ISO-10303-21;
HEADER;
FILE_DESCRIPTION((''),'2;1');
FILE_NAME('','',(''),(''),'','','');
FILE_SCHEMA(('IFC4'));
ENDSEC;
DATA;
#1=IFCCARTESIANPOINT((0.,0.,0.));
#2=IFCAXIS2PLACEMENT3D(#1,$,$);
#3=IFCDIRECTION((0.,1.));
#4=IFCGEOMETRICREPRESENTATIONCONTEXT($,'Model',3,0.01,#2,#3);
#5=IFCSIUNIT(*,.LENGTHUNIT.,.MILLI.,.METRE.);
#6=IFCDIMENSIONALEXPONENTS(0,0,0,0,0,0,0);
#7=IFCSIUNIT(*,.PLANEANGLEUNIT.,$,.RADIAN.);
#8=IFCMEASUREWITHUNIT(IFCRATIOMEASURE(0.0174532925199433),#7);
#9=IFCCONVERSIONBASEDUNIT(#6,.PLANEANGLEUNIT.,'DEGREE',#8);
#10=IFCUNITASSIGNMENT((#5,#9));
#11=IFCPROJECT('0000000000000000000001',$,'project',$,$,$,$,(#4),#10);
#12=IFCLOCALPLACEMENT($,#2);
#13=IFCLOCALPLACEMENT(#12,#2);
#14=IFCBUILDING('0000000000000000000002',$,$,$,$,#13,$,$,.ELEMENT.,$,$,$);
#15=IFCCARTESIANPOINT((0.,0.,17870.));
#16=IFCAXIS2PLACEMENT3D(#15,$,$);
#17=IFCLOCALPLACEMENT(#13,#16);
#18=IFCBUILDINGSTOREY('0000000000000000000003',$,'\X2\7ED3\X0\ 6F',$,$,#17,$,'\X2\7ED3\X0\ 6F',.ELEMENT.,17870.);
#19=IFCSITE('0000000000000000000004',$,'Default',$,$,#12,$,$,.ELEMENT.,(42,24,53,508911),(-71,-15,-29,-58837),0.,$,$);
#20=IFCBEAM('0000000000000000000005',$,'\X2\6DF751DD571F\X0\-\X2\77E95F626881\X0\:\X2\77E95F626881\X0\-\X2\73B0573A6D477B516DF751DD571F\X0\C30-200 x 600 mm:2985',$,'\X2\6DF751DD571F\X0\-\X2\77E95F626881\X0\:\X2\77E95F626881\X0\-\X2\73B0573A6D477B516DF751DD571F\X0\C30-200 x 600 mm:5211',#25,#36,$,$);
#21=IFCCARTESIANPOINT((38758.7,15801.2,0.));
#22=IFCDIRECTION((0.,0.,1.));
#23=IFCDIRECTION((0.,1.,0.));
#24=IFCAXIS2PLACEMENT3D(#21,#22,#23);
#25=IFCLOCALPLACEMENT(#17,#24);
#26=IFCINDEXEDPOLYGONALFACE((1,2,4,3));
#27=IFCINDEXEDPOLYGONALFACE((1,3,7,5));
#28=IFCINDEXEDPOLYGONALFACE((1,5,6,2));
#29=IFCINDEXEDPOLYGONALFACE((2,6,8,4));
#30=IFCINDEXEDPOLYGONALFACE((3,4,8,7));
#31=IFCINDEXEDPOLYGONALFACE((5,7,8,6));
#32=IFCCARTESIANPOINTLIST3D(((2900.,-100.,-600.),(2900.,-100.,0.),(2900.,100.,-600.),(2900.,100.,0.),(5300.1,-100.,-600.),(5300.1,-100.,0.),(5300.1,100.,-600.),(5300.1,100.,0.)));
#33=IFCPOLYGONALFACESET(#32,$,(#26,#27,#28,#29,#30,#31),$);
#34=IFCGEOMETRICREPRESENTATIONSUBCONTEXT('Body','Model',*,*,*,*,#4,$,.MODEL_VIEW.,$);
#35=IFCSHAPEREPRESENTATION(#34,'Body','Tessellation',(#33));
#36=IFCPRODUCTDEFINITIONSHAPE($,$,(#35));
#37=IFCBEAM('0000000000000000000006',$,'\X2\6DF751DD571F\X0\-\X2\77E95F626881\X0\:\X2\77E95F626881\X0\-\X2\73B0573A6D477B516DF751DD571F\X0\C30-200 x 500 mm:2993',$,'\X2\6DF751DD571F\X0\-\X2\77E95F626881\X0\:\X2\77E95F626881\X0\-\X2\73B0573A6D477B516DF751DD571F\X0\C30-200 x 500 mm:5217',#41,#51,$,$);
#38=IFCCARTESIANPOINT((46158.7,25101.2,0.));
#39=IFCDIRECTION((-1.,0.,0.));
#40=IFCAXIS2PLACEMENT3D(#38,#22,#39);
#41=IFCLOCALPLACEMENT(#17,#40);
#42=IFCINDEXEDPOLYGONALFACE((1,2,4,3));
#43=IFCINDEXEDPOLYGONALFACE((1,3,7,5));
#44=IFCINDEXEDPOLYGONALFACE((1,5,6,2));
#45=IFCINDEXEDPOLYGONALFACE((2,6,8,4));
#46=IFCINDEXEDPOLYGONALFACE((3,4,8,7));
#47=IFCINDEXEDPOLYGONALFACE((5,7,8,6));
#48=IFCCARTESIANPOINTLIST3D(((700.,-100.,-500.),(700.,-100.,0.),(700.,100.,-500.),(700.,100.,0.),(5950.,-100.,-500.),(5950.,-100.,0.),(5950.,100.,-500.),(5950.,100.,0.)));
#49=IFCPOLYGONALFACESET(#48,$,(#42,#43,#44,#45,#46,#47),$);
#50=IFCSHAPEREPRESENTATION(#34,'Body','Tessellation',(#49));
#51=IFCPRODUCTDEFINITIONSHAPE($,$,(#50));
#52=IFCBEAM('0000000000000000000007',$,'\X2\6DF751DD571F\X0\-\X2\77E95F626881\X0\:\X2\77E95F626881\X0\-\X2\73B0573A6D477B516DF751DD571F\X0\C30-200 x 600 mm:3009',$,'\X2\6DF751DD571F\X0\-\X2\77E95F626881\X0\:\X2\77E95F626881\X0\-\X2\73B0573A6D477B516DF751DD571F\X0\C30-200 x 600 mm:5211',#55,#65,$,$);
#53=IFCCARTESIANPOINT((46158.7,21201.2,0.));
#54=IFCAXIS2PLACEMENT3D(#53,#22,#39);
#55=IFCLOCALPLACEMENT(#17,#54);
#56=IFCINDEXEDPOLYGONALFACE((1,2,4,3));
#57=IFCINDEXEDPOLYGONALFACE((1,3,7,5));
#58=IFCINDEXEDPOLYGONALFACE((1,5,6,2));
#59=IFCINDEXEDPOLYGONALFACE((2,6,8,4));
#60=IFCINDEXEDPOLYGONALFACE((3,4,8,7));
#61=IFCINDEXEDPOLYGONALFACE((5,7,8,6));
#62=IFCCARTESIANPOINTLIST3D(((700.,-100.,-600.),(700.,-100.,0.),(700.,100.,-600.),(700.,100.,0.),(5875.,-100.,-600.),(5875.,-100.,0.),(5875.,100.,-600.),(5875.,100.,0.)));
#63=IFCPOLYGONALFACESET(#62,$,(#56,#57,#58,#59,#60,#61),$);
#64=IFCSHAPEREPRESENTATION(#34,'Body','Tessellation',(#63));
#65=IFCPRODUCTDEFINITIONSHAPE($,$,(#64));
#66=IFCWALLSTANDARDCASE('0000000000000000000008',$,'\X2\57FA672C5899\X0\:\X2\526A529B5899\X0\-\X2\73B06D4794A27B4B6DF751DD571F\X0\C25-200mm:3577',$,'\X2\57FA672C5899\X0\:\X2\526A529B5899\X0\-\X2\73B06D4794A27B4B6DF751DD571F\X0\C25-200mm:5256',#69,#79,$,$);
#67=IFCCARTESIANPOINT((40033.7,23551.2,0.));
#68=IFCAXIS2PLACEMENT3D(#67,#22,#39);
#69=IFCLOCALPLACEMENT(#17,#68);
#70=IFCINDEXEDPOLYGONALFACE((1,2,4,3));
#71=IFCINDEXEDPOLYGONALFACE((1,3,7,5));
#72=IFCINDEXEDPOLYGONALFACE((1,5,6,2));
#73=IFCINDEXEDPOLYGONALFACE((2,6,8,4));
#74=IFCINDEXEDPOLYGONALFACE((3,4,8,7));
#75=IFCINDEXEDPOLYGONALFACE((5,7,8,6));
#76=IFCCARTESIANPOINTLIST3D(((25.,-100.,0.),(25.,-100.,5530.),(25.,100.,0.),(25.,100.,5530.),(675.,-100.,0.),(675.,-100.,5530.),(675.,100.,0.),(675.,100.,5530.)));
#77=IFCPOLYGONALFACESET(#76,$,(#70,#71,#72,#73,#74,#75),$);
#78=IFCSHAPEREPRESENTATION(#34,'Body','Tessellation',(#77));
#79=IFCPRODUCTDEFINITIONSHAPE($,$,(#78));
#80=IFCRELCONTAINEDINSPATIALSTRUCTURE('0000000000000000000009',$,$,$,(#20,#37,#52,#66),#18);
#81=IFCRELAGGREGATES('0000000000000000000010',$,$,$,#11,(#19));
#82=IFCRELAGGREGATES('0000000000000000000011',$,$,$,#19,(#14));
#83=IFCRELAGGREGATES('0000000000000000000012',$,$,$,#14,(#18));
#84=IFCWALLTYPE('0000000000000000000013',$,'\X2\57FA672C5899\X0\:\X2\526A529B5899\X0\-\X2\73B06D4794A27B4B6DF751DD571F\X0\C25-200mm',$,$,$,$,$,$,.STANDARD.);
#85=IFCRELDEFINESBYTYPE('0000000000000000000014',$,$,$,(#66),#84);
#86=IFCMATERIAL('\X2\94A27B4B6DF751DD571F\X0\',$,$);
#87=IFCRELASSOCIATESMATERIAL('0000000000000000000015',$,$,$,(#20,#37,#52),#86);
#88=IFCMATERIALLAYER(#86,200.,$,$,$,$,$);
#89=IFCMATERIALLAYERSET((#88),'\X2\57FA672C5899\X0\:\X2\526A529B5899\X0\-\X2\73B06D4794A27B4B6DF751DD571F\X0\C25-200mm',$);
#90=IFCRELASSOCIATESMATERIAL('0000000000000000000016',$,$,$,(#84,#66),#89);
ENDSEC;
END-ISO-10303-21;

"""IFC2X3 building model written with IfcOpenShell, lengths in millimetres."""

from ifc_helpers import new_model, entity, si_unit, converted_unit, direction, frame, frame_2d, origin, place, context, subcontext, project, spatial, rectangle, extrude, material, layer, layer_set, layer_usage, type_object, element, save


model = new_model("IFC2X3")

# Units and contexts
model_context = context("Model", 3, precision=0.01, world=origin(), true_north=direction((0.0, 1.0)))
body_context = subcontext(model_context, "Body", "Model", "MODEL_VIEW")
ifc_project = project(units=[si_unit("LENGTHUNIT", "METRE", prefix="MILLI"), converted_unit("PLANEANGLEUNIT", "DEGREE", entity("IfcRatioMeasure", 0.0174532925199433), si_unit("PLANEANGLEUNIT", "RADIAN"), dimensions=[0, 0, 0, 0, 0, 0, 0])], contexts=[model_context])

# Site, building, storey
site_placement = place(None, origin())
site = spatial("IfcSite", under=ifc_project, at=site_placement, Name="Default", CompositionType="ELEMENT", RefLatitude=(42, 24, 53, 508911), RefLongitude=(-71, -15, -29, -58837), RefElevation=0.0)
building_placement = place(site_placement, origin())
building = spatial("IfcBuilding", under=site, at=building_placement, CompositionType="ELEMENT")
storey_placement = place(building_placement, frame((0.0, 0.0, 17870.0)))
storey = spatial("IfcBuildingStorey", under=building, at=storey_placement, Name="结 6F", LongName="结 6F", CompositionType="ELEMENT", Elevation=17870.0)

# Beams
ifc_material = material(Name="钢筋混凝土")
beam_1_placement = place(storey_placement, frame((38758.7, 15801.2, 0.0), z_axis=(0.0, 0.0, 1.0), x_axis=(0.0, 1.0, 0.0)))
element("IfcBeam", 1, at=beam_1_placement, inside=storey, material=ifc_material, Name="混凝土-矩形梁:矩形梁-现场浇筑混凝土C30-200 x 600 mm:2985", ObjectType="混凝土-矩形梁:矩形梁-现场浇筑混凝土C30-200 x 600 mm:5211", context=body_context, shape_type="SweptSolid", body=[
    extrude(rectangle(XDim=600.0, YDim=200.0, at=frame_2d((0.0, 0.0), x_axis=(1.0, 0.0))), frame((2900.0, 0.0, -300.0), z_axis=(1.0, 0.0, 0.0), x_axis=(0.0, 0.0, -1.0)), (0.0, 0.0, 1.0), 2400.0),
])
beam_2_placement = place(storey_placement, frame((46158.7, 25101.2, 0.0), z_axis=(0.0, 0.0, 1.0), x_axis=(-1.0, 0.0, 0.0)))
element("IfcBeam", 2, at=beam_2_placement, inside=storey, material=ifc_material, Name="混凝土-矩形梁:矩形梁-现场浇筑混凝土C30-200 x 500 mm:2993", ObjectType="混凝土-矩形梁:矩形梁-现场浇筑混凝土C30-200 x 500 mm:5217", context=body_context, shape_type="SweptSolid", body=[
    extrude(rectangle(XDim=500.0, YDim=200.0, at=frame_2d((0.0, 0.0), x_axis=(1.0, 0.0))), frame((700.0, 0.0, -250.0), z_axis=(1.0, 0.0, 0.0), x_axis=(0.0, 0.0, -1.0)), (0.0, 0.0, 1.0), 5250.0),
])
beam_3_placement = place(storey_placement, frame((46158.7, 21201.2, 0.0), z_axis=(0.0, 0.0, 1.0), x_axis=(-1.0, 0.0, 0.0)))
element("IfcBeam", 3, at=beam_3_placement, inside=storey, material=ifc_material, Name="混凝土-矩形梁:矩形梁-现场浇筑混凝土C30-200 x 600 mm:3009", ObjectType="混凝土-矩形梁:矩形梁-现场浇筑混凝土C30-200 x 600 mm:5211", context=body_context, shape_type="SweptSolid", body=[
    extrude(rectangle(XDim=600.0, YDim=200.0, at=frame_2d((0.0, 0.0), x_axis=(1.0, 0.0))), frame((700.0, 0.0, -300.0), z_axis=(1.0, 0.0, 0.0), x_axis=(0.0, 0.0, -1.0)), (0.0, 0.0, 1.0), 5175.0),
])

# Wall
ifc_layer = layer(ifc_material, 200.0)
ifc_layer_set = layer_set([ifc_layer], Name="基本墙:剪力墙-现浇钢筋混凝土C25-200mm")
wall_type = type_object("IfcWallType", Name="基本墙:剪力墙-现浇钢筋混凝土C25-200mm", PredefinedType="STANDARD", material=ifc_layer_set)
ifc_layer_usage_1 = layer_usage(ifc_layer_set, "AXIS2", "POSITIVE", -100.0)
wall_1_placement = place(storey_placement, frame((40033.7, 23551.2, 0.0), z_axis=(0.0, 0.0, 1.0), x_axis=(-1.0, 0.0, 0.0)))
element("IfcWallStandardCase", 4, at=wall_1_placement, inside=storey, type_object=wall_type, material=ifc_layer_usage_1, Name="基本墙:剪力墙-现浇钢筋混凝土C25-200mm:3577", ObjectType="基本墙:剪力墙-现浇钢筋混凝土C25-200mm:5256", context=body_context, shape_type="SweptSolid", body=[
    extrude(rectangle(XDim=650.0, YDim=200.0, at=frame_2d((350.0, 0.0), x_axis=(-1.0, 0.0))), origin(), (0.0, 0.0, 1.0), 5530.0),
])

save(model, "model.ifc")
